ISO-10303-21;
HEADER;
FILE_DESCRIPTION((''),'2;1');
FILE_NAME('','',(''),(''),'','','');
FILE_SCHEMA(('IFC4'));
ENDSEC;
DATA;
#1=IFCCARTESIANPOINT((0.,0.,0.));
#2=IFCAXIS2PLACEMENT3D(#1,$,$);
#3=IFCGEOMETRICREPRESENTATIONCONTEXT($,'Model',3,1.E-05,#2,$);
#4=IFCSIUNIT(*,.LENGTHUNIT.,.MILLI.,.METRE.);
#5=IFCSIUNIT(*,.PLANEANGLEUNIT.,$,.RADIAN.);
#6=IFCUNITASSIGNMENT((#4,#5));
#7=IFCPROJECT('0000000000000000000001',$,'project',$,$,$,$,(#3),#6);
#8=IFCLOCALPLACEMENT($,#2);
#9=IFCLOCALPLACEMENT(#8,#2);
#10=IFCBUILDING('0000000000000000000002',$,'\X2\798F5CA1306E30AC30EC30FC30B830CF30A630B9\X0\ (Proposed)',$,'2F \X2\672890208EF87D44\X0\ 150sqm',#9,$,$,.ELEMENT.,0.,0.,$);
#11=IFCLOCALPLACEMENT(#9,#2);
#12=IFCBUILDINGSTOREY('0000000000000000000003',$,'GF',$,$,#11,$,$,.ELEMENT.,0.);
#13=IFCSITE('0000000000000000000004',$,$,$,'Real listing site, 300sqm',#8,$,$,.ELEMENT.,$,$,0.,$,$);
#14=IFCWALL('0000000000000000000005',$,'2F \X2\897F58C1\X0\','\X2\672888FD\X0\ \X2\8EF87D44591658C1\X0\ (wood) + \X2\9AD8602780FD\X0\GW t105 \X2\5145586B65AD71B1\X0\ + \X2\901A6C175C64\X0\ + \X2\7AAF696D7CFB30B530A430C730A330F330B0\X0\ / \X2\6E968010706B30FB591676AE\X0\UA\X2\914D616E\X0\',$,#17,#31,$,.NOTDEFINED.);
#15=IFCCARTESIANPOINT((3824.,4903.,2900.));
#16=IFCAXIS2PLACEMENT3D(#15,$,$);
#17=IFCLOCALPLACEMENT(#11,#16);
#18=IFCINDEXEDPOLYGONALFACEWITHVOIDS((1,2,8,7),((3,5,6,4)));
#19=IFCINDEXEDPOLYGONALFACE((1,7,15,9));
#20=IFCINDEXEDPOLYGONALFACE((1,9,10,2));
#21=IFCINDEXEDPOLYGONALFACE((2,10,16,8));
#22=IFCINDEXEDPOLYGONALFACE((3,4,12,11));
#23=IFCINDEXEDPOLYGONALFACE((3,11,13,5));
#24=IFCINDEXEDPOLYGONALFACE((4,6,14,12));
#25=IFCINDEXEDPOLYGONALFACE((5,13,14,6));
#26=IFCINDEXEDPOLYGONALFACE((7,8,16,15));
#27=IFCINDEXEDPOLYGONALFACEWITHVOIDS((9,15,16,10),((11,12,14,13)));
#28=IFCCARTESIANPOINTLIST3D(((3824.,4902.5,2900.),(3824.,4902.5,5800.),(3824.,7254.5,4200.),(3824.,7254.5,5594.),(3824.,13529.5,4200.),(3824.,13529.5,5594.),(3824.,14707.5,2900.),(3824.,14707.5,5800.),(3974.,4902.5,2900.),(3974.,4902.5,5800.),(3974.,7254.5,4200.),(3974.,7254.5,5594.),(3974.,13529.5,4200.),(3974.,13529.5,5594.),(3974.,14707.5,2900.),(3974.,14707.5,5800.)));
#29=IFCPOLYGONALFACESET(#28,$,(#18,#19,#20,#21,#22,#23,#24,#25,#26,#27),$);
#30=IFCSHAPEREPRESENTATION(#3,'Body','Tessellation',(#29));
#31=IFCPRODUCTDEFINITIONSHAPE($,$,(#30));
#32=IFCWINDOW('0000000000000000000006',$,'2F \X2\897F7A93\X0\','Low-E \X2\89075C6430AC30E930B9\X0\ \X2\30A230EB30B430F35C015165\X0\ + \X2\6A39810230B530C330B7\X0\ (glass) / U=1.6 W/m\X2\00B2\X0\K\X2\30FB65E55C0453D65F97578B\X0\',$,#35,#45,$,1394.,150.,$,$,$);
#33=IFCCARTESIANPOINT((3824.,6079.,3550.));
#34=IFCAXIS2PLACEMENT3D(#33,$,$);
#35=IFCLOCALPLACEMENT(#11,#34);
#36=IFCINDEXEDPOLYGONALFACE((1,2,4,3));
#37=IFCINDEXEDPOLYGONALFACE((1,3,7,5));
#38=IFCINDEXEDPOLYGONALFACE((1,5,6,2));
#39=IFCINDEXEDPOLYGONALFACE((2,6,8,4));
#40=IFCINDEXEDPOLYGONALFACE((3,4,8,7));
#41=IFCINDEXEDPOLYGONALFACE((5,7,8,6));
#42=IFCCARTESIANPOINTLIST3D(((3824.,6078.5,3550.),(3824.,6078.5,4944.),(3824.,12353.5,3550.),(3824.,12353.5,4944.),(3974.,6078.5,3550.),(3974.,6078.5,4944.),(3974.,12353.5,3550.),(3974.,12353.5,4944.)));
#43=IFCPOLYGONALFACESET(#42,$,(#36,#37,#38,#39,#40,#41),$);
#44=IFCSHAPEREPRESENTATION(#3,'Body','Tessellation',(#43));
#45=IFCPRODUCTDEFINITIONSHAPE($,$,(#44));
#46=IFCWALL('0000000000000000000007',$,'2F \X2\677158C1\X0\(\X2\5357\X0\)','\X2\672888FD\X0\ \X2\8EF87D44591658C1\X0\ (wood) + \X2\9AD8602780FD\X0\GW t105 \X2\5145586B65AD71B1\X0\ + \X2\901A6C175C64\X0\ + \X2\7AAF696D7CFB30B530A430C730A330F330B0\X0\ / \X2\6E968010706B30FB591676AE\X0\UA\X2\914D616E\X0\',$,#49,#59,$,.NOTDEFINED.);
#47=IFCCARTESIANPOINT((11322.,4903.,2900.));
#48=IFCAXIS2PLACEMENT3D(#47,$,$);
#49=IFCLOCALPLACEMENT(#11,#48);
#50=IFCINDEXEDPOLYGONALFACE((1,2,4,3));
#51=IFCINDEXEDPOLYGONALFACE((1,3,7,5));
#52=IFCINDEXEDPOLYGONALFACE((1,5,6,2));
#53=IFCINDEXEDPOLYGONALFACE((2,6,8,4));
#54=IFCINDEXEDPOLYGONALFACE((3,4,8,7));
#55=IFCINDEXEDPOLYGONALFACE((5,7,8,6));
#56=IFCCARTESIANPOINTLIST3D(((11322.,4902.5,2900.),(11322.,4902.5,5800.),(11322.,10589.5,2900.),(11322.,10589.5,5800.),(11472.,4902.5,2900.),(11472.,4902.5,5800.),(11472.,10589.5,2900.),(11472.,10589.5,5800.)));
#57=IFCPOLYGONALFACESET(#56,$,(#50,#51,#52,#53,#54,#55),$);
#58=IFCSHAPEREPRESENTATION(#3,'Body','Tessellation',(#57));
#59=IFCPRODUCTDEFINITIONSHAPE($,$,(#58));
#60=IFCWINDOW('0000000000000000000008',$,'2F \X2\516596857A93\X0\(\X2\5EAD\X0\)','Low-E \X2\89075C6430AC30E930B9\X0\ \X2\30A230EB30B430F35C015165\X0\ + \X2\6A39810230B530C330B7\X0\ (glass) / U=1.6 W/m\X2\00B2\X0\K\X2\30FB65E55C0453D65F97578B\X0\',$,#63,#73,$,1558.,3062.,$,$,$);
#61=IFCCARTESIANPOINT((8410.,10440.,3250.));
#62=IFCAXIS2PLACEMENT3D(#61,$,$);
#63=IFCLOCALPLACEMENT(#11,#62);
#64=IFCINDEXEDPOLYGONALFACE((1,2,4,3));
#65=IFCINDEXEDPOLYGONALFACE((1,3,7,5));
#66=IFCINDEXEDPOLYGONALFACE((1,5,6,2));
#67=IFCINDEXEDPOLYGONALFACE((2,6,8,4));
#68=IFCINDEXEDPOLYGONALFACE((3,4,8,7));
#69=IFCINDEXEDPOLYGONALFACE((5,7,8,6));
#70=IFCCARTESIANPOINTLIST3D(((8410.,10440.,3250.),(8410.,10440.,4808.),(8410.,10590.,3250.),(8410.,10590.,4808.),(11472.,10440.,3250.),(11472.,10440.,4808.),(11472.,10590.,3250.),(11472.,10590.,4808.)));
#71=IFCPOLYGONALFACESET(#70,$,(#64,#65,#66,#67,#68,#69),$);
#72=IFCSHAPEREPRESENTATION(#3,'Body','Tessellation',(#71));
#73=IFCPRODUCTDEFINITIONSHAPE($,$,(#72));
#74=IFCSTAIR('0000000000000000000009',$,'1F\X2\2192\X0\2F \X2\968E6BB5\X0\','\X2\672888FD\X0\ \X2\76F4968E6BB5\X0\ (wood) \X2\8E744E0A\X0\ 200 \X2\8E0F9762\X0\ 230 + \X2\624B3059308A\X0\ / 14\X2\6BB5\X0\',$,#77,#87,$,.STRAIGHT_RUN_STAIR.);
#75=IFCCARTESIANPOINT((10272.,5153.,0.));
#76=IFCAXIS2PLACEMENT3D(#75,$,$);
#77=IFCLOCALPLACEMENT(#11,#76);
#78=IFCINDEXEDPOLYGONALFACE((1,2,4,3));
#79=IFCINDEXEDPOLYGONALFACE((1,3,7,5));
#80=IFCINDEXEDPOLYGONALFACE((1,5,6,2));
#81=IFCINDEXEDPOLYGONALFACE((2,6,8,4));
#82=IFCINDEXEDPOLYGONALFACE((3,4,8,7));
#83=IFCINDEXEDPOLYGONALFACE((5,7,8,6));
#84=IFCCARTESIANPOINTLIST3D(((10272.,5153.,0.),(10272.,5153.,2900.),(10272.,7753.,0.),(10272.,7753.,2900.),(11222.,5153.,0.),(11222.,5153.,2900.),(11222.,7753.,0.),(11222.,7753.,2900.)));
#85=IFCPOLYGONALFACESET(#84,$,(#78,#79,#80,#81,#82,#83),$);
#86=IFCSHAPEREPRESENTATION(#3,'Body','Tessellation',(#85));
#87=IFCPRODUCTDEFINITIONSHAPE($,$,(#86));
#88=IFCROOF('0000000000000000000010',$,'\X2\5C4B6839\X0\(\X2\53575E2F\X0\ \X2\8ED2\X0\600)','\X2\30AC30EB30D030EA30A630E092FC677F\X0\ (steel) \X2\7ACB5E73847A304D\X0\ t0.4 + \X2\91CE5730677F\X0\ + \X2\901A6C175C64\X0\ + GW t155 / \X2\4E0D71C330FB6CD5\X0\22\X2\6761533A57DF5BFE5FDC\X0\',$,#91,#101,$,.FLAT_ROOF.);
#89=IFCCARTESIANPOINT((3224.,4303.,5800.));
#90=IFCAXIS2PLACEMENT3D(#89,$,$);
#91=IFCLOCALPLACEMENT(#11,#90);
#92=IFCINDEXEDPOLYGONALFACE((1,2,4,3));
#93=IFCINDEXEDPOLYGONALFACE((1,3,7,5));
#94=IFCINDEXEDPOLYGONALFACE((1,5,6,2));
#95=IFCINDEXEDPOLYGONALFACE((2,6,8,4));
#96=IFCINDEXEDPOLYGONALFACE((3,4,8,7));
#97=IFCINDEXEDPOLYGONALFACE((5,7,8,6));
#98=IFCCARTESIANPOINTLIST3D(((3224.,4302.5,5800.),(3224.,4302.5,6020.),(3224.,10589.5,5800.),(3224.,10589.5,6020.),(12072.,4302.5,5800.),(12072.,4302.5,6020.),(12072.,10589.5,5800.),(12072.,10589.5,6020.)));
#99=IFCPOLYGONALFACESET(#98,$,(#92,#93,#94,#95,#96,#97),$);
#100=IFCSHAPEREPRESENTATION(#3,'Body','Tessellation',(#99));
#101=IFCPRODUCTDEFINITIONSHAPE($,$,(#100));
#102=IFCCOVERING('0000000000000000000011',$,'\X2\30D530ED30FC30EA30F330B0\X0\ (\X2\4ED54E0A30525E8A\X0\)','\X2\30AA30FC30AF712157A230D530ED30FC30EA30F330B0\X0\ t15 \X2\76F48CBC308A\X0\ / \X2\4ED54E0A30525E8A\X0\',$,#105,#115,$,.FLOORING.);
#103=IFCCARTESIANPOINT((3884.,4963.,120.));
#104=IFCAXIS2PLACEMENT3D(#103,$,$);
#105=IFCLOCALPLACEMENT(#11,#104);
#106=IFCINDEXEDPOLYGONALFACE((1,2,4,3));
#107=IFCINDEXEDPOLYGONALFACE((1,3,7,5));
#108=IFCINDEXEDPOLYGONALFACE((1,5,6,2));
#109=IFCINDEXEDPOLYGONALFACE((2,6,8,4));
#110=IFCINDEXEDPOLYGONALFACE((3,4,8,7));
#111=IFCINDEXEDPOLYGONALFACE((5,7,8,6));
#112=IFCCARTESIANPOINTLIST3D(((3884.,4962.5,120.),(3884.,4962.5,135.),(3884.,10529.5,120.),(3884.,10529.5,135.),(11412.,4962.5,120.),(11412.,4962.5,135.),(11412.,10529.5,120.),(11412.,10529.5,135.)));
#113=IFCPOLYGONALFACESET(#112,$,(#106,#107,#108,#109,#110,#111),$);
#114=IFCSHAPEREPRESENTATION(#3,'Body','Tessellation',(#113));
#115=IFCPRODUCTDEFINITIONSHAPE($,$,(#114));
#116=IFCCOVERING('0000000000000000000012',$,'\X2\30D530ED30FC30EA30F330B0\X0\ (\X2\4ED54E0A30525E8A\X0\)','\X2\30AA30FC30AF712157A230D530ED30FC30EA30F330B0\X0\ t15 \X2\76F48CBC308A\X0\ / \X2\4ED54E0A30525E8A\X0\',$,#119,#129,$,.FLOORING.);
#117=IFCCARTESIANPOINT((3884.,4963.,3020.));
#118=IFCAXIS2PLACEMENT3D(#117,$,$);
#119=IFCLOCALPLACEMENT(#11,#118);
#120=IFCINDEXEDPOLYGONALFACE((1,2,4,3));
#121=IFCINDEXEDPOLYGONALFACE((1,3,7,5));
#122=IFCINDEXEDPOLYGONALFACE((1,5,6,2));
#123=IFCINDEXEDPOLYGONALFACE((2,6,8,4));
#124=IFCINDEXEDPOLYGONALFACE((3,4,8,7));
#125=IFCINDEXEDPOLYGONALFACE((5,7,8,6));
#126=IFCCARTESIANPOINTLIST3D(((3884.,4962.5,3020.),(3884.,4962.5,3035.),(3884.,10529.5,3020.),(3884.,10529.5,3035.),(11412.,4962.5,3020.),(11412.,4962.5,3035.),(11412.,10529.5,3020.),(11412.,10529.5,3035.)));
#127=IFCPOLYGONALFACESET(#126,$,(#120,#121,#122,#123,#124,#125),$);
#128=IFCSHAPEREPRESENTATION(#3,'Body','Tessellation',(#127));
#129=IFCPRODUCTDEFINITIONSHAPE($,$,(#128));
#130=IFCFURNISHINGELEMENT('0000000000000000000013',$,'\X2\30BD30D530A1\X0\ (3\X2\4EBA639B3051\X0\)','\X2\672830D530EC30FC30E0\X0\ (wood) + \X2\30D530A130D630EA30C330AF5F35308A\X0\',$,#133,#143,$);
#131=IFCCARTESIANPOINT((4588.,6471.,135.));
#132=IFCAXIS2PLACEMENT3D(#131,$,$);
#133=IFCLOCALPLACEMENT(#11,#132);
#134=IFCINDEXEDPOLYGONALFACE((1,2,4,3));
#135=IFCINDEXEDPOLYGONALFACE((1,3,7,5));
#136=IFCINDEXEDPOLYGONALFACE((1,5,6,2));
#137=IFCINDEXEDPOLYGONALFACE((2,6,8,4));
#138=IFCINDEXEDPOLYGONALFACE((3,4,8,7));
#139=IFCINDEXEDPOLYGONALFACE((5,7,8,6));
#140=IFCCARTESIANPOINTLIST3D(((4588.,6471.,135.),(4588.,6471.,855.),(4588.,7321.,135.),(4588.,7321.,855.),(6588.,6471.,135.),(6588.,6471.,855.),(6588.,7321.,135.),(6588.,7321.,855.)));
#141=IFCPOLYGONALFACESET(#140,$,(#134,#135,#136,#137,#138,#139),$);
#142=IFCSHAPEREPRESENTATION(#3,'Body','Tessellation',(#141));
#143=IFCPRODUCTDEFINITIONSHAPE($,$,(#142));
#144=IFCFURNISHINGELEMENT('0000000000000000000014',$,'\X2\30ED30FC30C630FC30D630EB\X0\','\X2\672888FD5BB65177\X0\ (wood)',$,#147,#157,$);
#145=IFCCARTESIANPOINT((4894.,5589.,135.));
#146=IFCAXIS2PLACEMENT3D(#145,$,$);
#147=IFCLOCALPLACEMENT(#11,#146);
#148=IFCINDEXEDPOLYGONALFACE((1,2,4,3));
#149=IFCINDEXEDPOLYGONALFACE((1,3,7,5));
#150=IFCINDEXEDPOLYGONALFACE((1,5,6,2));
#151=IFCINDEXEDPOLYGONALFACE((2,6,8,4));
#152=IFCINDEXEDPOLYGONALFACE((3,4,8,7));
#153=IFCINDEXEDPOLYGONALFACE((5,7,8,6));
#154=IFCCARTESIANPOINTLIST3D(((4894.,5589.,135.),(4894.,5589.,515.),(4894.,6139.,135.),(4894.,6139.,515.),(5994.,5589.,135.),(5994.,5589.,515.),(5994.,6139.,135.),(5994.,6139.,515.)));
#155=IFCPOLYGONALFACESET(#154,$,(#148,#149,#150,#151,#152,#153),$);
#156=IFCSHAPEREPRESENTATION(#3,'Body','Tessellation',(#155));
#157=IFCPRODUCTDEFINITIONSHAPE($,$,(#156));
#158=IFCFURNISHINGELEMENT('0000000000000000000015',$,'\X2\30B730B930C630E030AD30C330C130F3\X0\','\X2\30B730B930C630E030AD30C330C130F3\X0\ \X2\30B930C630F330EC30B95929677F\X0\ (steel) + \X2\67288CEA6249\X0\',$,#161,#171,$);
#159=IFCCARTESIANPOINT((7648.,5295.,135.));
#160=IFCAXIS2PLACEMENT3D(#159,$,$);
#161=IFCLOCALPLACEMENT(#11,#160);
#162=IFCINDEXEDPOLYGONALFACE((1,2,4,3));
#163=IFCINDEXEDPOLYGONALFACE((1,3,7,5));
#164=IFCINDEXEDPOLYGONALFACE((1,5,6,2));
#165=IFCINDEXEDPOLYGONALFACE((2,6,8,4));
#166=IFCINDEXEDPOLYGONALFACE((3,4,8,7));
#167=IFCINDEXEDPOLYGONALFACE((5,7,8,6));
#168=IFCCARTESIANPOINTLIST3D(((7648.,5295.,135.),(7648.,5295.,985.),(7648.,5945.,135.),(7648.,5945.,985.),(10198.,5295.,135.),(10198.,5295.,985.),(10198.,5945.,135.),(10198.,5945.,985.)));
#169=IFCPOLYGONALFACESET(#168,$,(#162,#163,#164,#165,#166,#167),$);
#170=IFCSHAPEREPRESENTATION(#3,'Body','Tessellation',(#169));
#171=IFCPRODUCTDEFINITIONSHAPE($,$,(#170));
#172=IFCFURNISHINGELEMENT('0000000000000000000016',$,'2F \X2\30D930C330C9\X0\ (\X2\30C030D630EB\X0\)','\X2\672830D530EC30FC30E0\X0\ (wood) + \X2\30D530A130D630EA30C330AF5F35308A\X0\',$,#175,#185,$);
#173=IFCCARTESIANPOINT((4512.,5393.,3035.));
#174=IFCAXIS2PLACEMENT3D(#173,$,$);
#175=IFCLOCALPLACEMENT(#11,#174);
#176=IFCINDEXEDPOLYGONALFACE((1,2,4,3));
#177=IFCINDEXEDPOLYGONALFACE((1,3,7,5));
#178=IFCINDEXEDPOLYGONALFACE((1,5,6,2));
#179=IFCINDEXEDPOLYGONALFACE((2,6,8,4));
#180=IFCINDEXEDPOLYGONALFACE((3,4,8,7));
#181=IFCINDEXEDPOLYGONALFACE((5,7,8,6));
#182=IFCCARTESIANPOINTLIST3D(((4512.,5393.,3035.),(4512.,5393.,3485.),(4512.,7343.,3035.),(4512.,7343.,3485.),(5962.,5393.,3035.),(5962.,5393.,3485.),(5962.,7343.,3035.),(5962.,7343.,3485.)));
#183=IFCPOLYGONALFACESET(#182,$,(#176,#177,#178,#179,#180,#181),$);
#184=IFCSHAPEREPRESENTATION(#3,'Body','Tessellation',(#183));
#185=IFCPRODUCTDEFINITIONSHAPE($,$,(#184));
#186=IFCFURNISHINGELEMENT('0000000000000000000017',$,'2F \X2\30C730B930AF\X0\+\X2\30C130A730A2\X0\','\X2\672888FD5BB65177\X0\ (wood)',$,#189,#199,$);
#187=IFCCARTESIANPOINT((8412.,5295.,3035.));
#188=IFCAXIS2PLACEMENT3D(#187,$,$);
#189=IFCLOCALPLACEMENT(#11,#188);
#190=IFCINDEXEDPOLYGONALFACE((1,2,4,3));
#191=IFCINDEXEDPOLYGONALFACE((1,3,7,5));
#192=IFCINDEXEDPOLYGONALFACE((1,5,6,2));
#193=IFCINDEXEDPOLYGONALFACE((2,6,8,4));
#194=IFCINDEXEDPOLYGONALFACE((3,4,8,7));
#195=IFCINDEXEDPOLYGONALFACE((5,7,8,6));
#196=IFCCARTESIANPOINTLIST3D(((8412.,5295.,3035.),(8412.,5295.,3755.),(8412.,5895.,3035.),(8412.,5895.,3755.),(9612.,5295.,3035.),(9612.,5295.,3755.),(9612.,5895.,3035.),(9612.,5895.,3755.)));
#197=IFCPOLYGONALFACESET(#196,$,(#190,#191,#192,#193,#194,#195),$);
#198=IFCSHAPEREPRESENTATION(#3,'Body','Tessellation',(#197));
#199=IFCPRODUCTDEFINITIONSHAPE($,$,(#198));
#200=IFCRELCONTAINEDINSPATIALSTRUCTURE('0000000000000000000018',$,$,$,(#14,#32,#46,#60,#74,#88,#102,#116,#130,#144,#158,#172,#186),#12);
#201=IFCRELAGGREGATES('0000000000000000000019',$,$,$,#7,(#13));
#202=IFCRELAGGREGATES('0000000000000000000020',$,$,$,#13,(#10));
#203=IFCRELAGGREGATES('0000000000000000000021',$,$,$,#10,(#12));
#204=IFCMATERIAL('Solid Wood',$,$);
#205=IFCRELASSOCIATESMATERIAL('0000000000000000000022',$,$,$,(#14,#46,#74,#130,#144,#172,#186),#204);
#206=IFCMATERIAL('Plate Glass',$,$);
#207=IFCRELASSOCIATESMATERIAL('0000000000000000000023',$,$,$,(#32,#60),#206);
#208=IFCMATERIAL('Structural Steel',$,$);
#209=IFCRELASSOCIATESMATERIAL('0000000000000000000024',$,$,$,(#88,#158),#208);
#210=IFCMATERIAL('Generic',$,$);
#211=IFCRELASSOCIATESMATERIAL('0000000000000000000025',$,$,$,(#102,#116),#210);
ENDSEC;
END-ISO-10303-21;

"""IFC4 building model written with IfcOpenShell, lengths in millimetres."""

from ifc_helpers import new_model, si_unit, frame, frame_2d, origin, place, context, project, spatial, rectangle, extrude, material, element, fill, save


model = new_model("IFC4")

# Units and contexts
model_context = context("Model", 3, precision=1e-05, world=origin())
ifc_project = project(units=[si_unit("LENGTHUNIT", "METRE", prefix="MILLI"), si_unit("PLANEANGLEUNIT", "RADIAN")], contexts=[model_context])

# Site, building, storey
site_placement = place(None, origin())
site = spatial("IfcSite", under=ifc_project, at=site_placement, ObjectType="Real listing site, 300sqm", CompositionType="ELEMENT", RefElevation=0.0)
building_placement = place(site_placement, origin())
building = spatial("IfcBuilding", under=site, at=building_placement, Name="福岡のガレージハウス (Proposed)", ObjectType="2F 木造軸組 150sqm", CompositionType="ELEMENT", ElevationOfRefHeight=0.0, ElevationOfTerrain=0.0)
storey_placement = place(building_placement, origin())
storey = spatial("IfcBuildingStorey", under=building, at=storey_placement, Name="GF", CompositionType="ELEMENT", Elevation=0.0)

# Shared definitions
ifc_material_1 = material(Name="Solid Wood")

# Shared definitions
ifc_material_2 = material(Name="Plate Glass")

# Walls, openings, windows
wall_1_placement = place(storey_placement, frame((3824.0, 4903.0, 2900.0)))
wall_1 = element("IfcWall", 1, at=wall_1_placement, inside=storey, material=ifc_material_1, Name="2F 西壁", Description="木製 軸組外壁 (wood) + 高性能GW t105 充填断熱 + 通気層 + 窯業系サイディング / 準耐火・外皮UA配慮", PredefinedType="NOTDEFINED", context=model_context, shape_type="SweptSolid", body=[
    extrude(rectangle(XDim=150.0, YDim=9805.0, at=frame_2d((75.0, 4902.0))), frame((3824.0, 4903.0, 2900.0)), (0.0, 0.0, 1.0), 2900.0),
])
opening_1_placement = place(storey_placement, frame((3824.0, 6079.0, 3550.0)))
opening_1 = element("IfcOpeningElement", 2, at=opening_1_placement, cuts=wall_1, PredefinedType="NOTDEFINED", context=model_context, shape_type="SweptSolid", body=[
    extrude(rectangle(XDim=150.0, YDim=6275.0, at=frame_2d((75.0, 3137.0))), frame((3824.0, 6079.0, 3550.0)), (0.0, 0.0, 1.0), 1394.0),
])
window_1_placement = place(storey_placement, frame((3824.0, 6079.0, 3550.0)))
window_1 = element("IfcWindow", 3, at=window_1_placement, inside=storey, material=ifc_material_2, Name="2F 西窓", Description="Low-E 複層ガラス アルゴン封入 + 樹脂サッシ (glass) / U=1.6 W/m²K・日射取得型", OverallHeight=1394.0, OverallWidth=150.0, context=model_context, shape_type="SweptSolid", body=[
    extrude(rectangle(XDim=150.0, YDim=6275.0, at=frame_2d((75.0, 3137.0))), frame((3824.0, 6079.0, 3550.0)), (0.0, 0.0, 1.0), 1394.0),
])
fill(opening_1, window_1)
wall_2_placement = place(storey_placement, frame((11322.0, 4903.0, 2900.0)))
wall_2 = element("IfcWall", 4, at=wall_2_placement, inside=storey, material=ifc_material_1, Name="2F 東壁(南)", Description="木製 軸組外壁 (wood) + 高性能GW t105 充填断熱 + 通気層 + 窯業系サイディング / 準耐火・外皮UA配慮", PredefinedType="NOTDEFINED", context=model_context, shape_type="SweptSolid", body=[
    extrude(rectangle(XDim=150.0, YDim=5687.0, at=frame_2d((75.0, 2843.0))), frame((11322.0, 4903.0, 2900.0)), (0.0, 0.0, 1.0), 2900.0),
])
opening_2_placement = place(storey_placement, frame((8410.0, 10440.0, 3250.0)))
opening_2 = element("IfcOpeningElement", 5, at=opening_2_placement, cuts=wall_2, PredefinedType="NOTDEFINED", context=model_context, shape_type="SweptSolid", body=[
    extrude(rectangle(XDim=3062.0, YDim=150.0, at=frame_2d((1531.0, 75.0))), frame((8410.0, 10440.0, 3250.0)), (0.0, 0.0, 1.0), 1558.0),
])
window_2_placement = place(storey_placement, frame((8410.0, 10440.0, 3250.0)))
window_2 = element("IfcWindow", 6, at=window_2_placement, inside=storey, material=ifc_material_2, Name="2F 入隅窓(庭)", Description="Low-E 複層ガラス アルゴン封入 + 樹脂サッシ (glass) / U=1.6 W/m²K・日射取得型", OverallHeight=1558.0, OverallWidth=3062.0, context=model_context, shape_type="SweptSolid", body=[
    extrude(rectangle(XDim=3062.0, YDim=150.0, at=frame_2d((1531.0, 75.0))), frame((8410.0, 10440.0, 3250.0)), (0.0, 0.0, 1.0), 1558.0),
])
fill(opening_2, window_2)

# Stair
stair_placement = place(storey_placement, frame((10272.0, 5153.0, 0.0)))
element("IfcStair", 7, at=stair_placement, inside=storey, material=ifc_material_1, Name="1F→2F 階段", Description="木製 直階段 (wood) 蹴上 200 踏面 230 + 手すり / 14段", PredefinedType="STRAIGHT_RUN_STAIR", context=model_context, shape_type="SweptSolid", body=[
    extrude(rectangle(XDim=950.0, YDim=2600.0, at=frame_2d((475.0, 1300.0))), frame((10272.0, 5153.0, 0.0)), (0.0, 0.0, 1.0), 2900.0),
])

# Roof
ifc_material_3 = material(Name="Structural Steel")
for number, where, name in (
    (8, (3224.0, 4303.0, 5800.0), "屋根(南帯 軒600)"),
):
    element("IfcRoof", number, at=place(storey_placement, frame(where)), inside=storey, material=ifc_material_3, Name=name, Description="ガルバリウム鋼板 (steel) 立平葺き t0.4 + 野地板 + 通気層 + GW t155 / 不燃・法22条区域対応", PredefinedType="FLAT_ROOF", context=model_context, shape_type="SweptSolid", body=[
        extrude(rectangle(XDim=8848.0, YDim=6287.0, at=frame_2d((4424.0, 3143.0))), frame((3224.0, 4303.0, 5800.0)), (0.0, 0.0, 1.0), 220.0),
    ])

# Coverings
ifc_material_4 = material(Name="Generic")
covering_1_placement = place(storey_placement, frame((3884.0, 4963.0, 120.0)))
element("IfcCovering", 9, at=covering_1_placement, inside=storey, material=ifc_material_4, Name="フローリング (仕上げ床)", Description="オーク無垢フローリング t15 直貼り / 仕上げ床", PredefinedType="FLOORING", context=model_context, shape_type="SweptSolid", body=[
    extrude(rectangle(XDim=7528.0, YDim=5567.0, at=frame_2d((3764.0, 2783.0))), frame((3884.0, 4963.0, 120.0)), (0.0, 0.0, 1.0), 15.0),
])
covering_2_placement = place(storey_placement, frame((3884.0, 4963.0, 3020.0)))
element("IfcCovering", 10, at=covering_2_placement, inside=storey, material=ifc_material_4, Name="フローリング (仕上げ床)", Description="オーク無垢フローリング t15 直貼り / 仕上げ床", PredefinedType="FLOORING", context=model_context, shape_type="SweptSolid", body=[
    extrude(rectangle(XDim=7528.0, YDim=5567.0, at=frame_2d((3764.0, 2783.0))), frame((3884.0, 4963.0, 3020.0)), (0.0, 0.0, 1.0), 15.0),
])

# Furnishing elements
furnishing_1_placement = place(storey_placement, frame((4588.0, 6471.0, 135.0)))
element("IfcFurnishingElement", 11, at=furnishing_1_placement, inside=storey, material=ifc_material_1, Name="ソファ (3人掛け)", Description="木フレーム (wood) + ファブリック張り", context=model_context, shape_type="SweptSolid", body=[
    extrude(rectangle(XDim=2000.0, YDim=850.0, at=frame_2d((1000.0, 425.0))), frame((4588.0, 6471.0, 135.0)), (0.0, 0.0, 1.0), 720.0),
])
furnishing_2_placement = place(storey_placement, frame((4894.0, 5589.0, 135.0)))
element("IfcFurnishingElement", 12, at=furnishing_2_placement, inside=storey, material=ifc_material_1, Name="ローテーブル", Description="木製家具 (wood)", context=model_context, shape_type="SweptSolid", body=[
    extrude(rectangle(XDim=1100.0, YDim=550.0, at=frame_2d((550.0, 275.0))), frame((4894.0, 5589.0, 135.0)), (0.0, 0.0, 1.0), 380.0),
])
furnishing_3_placement = place(storey_placement, frame((7648.0, 5295.0, 135.0)))
element("IfcFurnishingElement", 13, at=furnishing_3_placement, inside=storey, material=ifc_material_3, Name="システムキッチン", Description="システムキッチン ステンレス天板 (steel) + 木質扉", context=model_context, shape_type="SweptSolid", body=[
    extrude(rectangle(XDim=2550.0, YDim=650.0, at=frame_2d((1275.0, 325.0))), frame((7648.0, 5295.0, 135.0)), (0.0, 0.0, 1.0), 850.0),
])
furnishing_4_placement = place(storey_placement, frame((4512.0, 5393.0, 3035.0)))
element("IfcFurnishingElement", 14, at=furnishing_4_placement, inside=storey, material=ifc_material_1, Name="2F ベッド (ダブル)", Description="木フレーム (wood) + ファブリック張り", context=model_context, shape_type="SweptSolid", body=[
    extrude(rectangle(XDim=1450.0, YDim=1950.0, at=frame_2d((725.0, 975.0))), frame((4512.0, 5393.0, 3035.0)), (0.0, 0.0, 1.0), 450.0),
])
furnishing_5_placement = place(storey_placement, frame((8412.0, 5295.0, 3035.0)))
element("IfcFurnishingElement", 15, at=furnishing_5_placement, inside=storey, material=ifc_material_1, Name="2F デスク+チェア", Description="木製家具 (wood)", context=model_context, shape_type="SweptSolid", body=[
    extrude(rectangle(XDim=1200.0, YDim=600.0, at=frame_2d((600.0, 300.0))), frame((8412.0, 5295.0, 3035.0)), (0.0, 0.0, 1.0), 720.0),
])

save(model, "model.ifc")
